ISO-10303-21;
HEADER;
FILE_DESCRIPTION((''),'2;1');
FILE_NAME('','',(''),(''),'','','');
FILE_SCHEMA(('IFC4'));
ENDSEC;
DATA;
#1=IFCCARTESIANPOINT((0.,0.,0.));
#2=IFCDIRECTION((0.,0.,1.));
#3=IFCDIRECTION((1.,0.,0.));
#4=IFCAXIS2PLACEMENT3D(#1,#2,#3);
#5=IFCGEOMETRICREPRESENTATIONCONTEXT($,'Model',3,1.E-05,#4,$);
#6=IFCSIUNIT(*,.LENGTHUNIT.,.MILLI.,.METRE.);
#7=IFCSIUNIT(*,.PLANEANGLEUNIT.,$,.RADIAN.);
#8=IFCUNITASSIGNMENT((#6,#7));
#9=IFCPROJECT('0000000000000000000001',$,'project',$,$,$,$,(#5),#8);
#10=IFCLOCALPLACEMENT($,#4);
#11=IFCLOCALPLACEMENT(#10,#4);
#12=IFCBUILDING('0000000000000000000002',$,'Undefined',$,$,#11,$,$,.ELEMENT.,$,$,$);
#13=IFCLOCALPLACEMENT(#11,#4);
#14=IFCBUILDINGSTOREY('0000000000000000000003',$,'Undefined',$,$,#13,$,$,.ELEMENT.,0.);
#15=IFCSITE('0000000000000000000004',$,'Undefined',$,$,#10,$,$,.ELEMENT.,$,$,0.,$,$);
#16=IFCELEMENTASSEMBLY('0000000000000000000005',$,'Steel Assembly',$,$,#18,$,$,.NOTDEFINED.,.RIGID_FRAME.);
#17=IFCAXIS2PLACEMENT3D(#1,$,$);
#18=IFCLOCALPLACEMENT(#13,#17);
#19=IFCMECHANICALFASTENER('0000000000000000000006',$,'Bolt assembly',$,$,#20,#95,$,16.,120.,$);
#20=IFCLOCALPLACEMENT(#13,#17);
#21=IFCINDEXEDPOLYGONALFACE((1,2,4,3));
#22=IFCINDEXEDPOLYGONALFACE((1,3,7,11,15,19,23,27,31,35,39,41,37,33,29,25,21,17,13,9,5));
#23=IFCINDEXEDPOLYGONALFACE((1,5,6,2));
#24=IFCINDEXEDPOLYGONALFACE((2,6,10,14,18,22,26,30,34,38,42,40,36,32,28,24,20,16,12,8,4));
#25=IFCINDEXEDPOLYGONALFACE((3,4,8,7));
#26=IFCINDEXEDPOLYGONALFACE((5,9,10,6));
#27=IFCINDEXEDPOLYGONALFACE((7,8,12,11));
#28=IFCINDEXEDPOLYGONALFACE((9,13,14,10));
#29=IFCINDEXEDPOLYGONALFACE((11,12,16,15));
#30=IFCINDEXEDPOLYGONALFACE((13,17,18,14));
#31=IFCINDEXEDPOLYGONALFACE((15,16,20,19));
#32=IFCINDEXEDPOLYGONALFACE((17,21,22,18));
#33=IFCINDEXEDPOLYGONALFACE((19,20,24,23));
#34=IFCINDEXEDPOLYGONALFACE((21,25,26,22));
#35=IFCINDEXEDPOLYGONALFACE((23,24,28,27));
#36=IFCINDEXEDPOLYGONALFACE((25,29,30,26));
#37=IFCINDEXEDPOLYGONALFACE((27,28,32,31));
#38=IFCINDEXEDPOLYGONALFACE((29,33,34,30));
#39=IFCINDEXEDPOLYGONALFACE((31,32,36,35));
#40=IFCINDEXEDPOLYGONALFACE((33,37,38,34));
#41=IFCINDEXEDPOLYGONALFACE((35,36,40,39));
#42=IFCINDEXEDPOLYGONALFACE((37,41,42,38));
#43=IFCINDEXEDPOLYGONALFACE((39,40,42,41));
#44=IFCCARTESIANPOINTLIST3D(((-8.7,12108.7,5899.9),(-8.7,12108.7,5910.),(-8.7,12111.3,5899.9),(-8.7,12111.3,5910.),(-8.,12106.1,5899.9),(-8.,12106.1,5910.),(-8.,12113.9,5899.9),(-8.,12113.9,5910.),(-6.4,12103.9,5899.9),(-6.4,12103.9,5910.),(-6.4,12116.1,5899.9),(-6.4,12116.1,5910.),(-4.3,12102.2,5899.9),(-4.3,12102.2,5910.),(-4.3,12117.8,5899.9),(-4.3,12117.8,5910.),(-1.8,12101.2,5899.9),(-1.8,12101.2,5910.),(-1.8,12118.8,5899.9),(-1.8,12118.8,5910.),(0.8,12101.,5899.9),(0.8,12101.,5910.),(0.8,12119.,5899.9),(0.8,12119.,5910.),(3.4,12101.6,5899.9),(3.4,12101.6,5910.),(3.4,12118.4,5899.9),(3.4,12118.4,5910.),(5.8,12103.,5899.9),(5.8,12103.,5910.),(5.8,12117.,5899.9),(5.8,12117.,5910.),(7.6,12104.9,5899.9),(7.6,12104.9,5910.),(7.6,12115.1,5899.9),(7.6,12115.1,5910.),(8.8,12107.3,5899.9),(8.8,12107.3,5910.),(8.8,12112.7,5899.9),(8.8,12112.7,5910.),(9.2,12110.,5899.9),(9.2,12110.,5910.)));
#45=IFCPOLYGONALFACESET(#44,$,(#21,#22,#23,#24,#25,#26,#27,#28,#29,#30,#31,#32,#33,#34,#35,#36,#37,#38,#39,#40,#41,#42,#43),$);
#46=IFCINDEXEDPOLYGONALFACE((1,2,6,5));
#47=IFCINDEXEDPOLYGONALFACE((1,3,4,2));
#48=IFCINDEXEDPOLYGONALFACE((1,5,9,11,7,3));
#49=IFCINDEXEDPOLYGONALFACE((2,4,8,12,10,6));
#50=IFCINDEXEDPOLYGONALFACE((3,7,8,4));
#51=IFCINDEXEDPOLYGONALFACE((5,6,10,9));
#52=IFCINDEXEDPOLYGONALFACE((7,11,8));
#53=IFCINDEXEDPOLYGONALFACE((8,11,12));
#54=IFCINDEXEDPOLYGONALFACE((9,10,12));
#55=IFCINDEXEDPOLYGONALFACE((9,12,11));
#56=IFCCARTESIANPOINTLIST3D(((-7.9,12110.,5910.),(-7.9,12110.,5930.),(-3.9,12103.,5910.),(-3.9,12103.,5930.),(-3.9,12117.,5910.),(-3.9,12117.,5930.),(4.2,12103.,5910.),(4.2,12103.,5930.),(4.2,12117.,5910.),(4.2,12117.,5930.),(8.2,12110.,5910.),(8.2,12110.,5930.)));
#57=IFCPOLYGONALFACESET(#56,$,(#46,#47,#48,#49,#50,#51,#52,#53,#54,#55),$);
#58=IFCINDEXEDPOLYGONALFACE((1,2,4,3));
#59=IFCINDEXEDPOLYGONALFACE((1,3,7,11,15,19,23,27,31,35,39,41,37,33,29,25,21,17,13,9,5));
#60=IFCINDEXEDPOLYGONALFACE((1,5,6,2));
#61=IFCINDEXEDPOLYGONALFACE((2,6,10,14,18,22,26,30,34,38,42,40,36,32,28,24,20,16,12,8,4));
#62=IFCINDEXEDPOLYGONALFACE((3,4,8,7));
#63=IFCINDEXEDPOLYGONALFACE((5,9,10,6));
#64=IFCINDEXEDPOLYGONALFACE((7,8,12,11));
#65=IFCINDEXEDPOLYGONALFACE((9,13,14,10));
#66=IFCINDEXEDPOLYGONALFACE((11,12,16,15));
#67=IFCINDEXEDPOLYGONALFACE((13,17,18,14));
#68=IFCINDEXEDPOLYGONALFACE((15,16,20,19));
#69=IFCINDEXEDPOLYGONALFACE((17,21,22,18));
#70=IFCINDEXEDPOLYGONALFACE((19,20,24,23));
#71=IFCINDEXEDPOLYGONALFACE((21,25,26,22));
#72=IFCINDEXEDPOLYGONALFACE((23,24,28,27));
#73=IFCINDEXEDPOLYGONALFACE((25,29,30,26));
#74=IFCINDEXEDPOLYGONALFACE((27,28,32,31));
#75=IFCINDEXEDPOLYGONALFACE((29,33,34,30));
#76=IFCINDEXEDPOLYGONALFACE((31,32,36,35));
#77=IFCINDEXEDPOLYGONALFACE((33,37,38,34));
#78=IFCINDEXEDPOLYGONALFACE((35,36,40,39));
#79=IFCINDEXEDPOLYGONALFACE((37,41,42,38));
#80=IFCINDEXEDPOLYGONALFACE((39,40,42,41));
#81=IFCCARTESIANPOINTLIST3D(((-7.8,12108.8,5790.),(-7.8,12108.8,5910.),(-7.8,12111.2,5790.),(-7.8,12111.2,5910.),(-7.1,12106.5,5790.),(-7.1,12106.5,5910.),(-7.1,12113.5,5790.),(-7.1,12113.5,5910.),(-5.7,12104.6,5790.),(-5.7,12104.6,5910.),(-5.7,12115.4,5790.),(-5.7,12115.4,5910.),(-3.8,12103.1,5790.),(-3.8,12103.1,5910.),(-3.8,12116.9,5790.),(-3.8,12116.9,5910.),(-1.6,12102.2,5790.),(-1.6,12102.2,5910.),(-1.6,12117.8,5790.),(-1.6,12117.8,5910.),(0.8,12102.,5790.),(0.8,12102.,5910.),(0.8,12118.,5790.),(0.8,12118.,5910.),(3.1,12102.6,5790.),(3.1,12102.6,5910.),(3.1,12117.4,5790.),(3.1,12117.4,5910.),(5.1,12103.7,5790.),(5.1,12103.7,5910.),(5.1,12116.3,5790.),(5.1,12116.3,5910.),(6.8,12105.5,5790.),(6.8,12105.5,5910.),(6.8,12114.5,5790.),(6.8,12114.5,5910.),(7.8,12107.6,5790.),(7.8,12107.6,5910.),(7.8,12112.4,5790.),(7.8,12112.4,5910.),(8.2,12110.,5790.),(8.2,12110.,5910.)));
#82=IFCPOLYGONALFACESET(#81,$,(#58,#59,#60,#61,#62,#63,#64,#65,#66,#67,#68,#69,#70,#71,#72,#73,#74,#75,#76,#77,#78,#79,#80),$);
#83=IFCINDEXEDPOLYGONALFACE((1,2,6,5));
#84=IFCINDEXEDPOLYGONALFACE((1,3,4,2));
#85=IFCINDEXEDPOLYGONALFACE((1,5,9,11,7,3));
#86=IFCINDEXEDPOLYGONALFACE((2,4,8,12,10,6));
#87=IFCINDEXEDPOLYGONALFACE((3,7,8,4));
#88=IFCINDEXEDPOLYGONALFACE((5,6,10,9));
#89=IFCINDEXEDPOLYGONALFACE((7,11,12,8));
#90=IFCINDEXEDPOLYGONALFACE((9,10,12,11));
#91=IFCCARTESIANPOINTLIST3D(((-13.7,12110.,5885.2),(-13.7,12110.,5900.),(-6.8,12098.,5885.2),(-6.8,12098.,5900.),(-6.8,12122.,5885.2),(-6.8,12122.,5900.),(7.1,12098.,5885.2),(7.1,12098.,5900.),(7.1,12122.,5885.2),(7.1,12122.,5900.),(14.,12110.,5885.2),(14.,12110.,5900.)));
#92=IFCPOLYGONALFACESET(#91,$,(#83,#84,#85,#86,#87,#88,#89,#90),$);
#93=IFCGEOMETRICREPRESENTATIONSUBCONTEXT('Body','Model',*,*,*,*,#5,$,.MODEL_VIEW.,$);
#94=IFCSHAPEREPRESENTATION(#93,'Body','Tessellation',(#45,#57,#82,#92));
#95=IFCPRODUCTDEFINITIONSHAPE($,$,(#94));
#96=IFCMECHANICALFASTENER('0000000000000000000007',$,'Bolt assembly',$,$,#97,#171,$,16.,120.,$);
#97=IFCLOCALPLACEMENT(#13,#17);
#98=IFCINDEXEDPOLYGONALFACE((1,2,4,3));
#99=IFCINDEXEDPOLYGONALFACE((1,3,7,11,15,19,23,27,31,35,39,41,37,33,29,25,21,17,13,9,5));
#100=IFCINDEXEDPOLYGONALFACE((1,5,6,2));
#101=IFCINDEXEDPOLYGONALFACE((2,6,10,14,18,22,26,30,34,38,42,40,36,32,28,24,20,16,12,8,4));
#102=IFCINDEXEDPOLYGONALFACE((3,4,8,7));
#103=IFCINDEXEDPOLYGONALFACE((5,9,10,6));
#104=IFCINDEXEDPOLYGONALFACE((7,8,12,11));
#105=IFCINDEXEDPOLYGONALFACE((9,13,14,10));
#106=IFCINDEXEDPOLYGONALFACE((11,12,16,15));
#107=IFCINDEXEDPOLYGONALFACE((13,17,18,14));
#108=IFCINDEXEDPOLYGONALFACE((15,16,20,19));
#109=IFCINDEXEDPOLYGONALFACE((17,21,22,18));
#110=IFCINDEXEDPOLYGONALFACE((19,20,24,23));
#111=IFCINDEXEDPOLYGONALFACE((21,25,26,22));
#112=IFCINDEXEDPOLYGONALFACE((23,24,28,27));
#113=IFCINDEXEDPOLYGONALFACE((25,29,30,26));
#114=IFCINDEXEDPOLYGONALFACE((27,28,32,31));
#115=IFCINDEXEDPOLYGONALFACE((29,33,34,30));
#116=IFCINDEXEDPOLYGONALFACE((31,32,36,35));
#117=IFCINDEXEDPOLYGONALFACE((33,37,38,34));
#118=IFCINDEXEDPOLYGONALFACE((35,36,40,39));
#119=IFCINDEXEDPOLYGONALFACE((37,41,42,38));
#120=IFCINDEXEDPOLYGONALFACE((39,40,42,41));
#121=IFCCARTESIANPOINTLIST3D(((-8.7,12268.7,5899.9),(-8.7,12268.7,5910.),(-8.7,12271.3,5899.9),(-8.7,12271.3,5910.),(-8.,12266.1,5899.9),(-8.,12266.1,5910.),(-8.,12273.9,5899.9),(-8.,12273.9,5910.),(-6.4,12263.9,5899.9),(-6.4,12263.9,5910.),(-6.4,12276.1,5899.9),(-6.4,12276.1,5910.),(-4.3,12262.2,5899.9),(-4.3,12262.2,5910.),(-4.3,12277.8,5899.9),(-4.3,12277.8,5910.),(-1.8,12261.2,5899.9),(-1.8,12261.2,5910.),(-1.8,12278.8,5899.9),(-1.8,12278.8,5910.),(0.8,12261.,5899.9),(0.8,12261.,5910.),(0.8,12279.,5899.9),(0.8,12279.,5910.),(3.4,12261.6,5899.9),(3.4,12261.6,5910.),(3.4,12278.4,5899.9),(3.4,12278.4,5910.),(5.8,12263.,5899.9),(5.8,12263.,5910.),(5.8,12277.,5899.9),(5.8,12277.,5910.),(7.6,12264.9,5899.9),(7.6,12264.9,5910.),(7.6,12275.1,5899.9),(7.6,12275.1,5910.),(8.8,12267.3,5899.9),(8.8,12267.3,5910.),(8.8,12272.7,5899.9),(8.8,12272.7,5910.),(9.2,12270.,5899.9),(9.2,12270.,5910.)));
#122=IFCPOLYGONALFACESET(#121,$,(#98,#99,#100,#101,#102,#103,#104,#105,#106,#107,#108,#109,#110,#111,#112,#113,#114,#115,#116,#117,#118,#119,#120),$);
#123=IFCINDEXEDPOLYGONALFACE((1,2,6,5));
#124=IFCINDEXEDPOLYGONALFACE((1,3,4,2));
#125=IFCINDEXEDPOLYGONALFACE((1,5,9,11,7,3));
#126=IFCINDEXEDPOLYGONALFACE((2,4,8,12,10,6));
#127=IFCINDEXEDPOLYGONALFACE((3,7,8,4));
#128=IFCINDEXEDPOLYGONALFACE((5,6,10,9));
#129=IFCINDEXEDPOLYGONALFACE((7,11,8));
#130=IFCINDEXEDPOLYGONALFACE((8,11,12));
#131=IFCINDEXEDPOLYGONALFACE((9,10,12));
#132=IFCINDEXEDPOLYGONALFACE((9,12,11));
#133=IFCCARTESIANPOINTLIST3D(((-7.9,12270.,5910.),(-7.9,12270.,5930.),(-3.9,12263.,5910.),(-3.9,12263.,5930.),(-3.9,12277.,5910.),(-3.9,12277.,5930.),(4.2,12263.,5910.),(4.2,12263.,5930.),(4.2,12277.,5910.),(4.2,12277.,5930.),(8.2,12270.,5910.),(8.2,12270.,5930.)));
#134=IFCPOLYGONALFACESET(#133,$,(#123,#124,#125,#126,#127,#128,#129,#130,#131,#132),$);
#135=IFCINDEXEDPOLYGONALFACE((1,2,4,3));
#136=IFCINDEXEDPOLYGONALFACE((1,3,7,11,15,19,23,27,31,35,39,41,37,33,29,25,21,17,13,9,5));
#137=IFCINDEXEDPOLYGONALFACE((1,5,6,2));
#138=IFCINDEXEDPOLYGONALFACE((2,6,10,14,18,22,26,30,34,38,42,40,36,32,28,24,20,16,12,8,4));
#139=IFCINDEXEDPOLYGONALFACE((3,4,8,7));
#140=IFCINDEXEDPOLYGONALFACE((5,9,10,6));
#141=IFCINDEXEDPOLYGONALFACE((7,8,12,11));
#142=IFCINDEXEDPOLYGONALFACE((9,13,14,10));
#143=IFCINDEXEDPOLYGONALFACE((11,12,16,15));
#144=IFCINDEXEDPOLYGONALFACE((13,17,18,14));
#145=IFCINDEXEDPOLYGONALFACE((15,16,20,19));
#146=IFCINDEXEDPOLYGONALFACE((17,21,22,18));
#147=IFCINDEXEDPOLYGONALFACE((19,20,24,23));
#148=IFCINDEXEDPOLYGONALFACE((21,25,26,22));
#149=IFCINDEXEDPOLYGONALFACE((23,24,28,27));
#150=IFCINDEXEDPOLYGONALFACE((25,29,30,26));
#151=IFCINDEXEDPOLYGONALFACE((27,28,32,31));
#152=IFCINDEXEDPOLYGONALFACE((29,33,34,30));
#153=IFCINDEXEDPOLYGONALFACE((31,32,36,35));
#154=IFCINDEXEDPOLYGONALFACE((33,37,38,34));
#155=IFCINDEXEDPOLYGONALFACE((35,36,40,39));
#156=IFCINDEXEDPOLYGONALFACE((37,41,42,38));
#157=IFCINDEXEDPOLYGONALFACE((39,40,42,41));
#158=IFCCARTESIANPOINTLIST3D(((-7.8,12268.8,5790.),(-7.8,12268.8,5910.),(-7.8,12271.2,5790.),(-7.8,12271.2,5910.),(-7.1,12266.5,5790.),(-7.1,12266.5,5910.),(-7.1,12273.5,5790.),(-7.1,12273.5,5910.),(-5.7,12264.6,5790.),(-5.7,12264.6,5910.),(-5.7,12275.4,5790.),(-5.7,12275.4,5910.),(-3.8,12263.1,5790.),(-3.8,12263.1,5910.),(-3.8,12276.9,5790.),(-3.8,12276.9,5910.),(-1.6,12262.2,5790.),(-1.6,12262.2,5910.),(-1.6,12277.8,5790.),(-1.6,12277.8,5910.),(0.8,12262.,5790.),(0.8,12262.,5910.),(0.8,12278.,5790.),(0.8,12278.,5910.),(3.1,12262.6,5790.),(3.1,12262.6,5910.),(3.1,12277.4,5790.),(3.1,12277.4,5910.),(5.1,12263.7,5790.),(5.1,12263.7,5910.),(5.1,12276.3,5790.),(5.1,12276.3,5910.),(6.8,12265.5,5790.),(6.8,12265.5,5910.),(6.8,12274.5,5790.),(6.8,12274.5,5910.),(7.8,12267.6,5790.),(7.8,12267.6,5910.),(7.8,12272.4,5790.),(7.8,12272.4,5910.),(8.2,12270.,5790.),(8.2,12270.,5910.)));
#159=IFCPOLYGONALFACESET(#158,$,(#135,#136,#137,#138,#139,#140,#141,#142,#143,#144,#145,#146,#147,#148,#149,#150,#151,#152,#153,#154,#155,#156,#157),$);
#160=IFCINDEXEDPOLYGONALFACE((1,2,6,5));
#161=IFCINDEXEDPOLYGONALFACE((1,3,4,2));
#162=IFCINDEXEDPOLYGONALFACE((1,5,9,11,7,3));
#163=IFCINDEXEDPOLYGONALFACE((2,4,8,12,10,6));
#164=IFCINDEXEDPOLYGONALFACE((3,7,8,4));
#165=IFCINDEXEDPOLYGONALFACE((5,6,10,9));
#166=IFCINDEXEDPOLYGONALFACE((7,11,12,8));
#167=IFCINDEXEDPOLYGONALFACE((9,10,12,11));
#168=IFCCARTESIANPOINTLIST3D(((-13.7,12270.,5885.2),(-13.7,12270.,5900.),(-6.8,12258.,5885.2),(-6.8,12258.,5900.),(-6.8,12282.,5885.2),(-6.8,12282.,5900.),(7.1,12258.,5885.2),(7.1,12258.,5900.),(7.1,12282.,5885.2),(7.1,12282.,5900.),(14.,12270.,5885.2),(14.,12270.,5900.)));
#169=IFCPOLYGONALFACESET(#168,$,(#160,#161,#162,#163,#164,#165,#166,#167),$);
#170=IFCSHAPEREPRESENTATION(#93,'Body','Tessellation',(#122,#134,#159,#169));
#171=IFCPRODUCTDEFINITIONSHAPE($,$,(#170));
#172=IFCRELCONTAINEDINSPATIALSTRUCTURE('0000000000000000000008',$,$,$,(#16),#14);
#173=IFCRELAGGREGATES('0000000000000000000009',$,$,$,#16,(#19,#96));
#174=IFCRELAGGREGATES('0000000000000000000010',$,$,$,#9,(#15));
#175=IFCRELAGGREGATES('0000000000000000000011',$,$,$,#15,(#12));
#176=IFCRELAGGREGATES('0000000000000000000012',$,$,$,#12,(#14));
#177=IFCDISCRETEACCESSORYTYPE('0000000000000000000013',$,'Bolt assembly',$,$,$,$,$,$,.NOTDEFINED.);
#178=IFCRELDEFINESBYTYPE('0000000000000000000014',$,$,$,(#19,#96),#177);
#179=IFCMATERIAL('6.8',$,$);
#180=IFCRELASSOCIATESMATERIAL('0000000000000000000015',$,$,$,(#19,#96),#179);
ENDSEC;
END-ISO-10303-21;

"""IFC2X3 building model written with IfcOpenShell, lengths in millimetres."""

from ifc_helpers import new_model, si_unit, frame, origin_with_axes, origin_2d_with_axis, place, context, subcontext, project, spatial, polyline, circle, outline, extrude, source, transform, mapped, material, type_object, element, aggregate, save


model = new_model("IFC2X3")

# Units and contexts
model_context = context("Model", 3, precision=1e-05, world=origin_with_axes())
body_context = subcontext(model_context, "Body", "Model", "MODEL_VIEW")
ifc_project = project(units=[si_unit("LENGTHUNIT", "METRE", prefix="MILLI"), si_unit("PLANEANGLEUNIT", "RADIAN")], contexts=[model_context])

# Site, building, storey
site_placement = place(None, origin_with_axes())
site = spatial("IfcSite", under=ifc_project, at=site_placement, Name="Undefined", CompositionType="ELEMENT", RefElevation=0.0)
building_placement = place(site_placement, origin_with_axes())
building = spatial("IfcBuilding", under=site, at=building_placement, Name="Undefined", CompositionType="ELEMENT")
storey_placement = place(building_placement, origin_with_axes())
storey = spatial("IfcBuildingStorey", under=building, at=storey_placement, Name="Undefined", CompositionType="ELEMENT", Elevation=0.0)

# Element assembly
assembly_1_placement = place(storey_placement, origin_with_axes())
assembly_1 = element("IfcElementAssembly", 1, at=assembly_1_placement, inside=storey, Name="Steel Assembly", AssemblyPlace="NOTDEFINED", PredefinedType="RIGID_FRAME")

# Mechanical fasteners
ifc_material_1 = material(Name="6.8")
discrete_accessory_type_1 = type_object("IfcDiscreteAccessoryType", Name="Bolt assembly")
shared_shape_1 = source(origin_with_axes(), body_context, "Body", "SweptSolid", [
    extrude(circle(Radius=9.0, at=origin_2d_with_axis()), frame((0.0, -10.0, 0.0), z_axis=(0.0, 1.0, 0.0), x_axis=(1.0, 0.0, 0.0)), (0.0, 0.0, 1.0), 10.1),
    extrude(outline(polyline([(8.1, 0.0), (4.0, 7.0), (-4.0, 7.0), (-8.1, 0.0), (-4.0, -7.0), (4.0, -7.0), (8.1, 0.0)])), frame((0.0, -30.0, 0.0), z_axis=(0.0, 1.0, 0.0), x_axis=(1.0, 0.0, 0.0)), (0.0, 0.0, 1.0), 20.0),
    extrude(circle(Radius=8.0, at=origin_2d_with_axis()), frame((0.0, -10.0, 0.0), z_axis=(0.0, 1.0, 0.0), x_axis=(1.0, 0.0, 0.0)), (0.0, 0.0, 1.0), 120.0),
    extrude(outline(polyline([(13.9, 0.0), (6.9, 12.0), (-6.9, 12.0), (-13.9, 0.0), (-6.9, -12.0), (6.9, -12.0), (13.9, 0.0)])), frame((0.0, 0.0, 0.0), z_axis=(0.0, 1.0, 0.0), x_axis=(1.0, 0.0, 0.0)), (0.0, 0.0, 1.0), 14.8),
])
mechanical_fastener_1_placement = place(assembly_1_placement, frame((0.2, 12110.0, 5900.0), z_axis=(0.0, 1.0, 0.0), x_axis=(1.0, 0.0, 0.0)))
mechanical_fastener_1 = element("IfcMechanicalFastener", 2, at=mechanical_fastener_1_placement, type_object=discrete_accessory_type_1, material=ifc_material_1, Name="Bolt assembly", NominalDiameter=16.0, NominalLength=120.0, context=body_context, shape_type="MappedRepresentation", body=[
    mapped(shared_shape_1, transform((0.0, 0.0, 0.0))),
])
mechanical_fastener_2_placement = place(assembly_1_placement, frame((0.2, 12270.0, 5900.0), z_axis=(0.0, 1.0, 0.0), x_axis=(1.0, 0.0, 0.0)))
mechanical_fastener_2 = element("IfcMechanicalFastener", 3, at=mechanical_fastener_2_placement, type_object=discrete_accessory_type_1, material=ifc_material_1, Name="Bolt assembly", NominalDiameter=16.0, NominalLength=120.0, context=body_context, shape_type="MappedRepresentation", body=[
    mapped(shared_shape_1, transform((0.0, 0.0, 0.0))),
])
aggregate(assembly_1, [mechanical_fastener_1, mechanical_fastener_2])

save(model, "model.ifc")
